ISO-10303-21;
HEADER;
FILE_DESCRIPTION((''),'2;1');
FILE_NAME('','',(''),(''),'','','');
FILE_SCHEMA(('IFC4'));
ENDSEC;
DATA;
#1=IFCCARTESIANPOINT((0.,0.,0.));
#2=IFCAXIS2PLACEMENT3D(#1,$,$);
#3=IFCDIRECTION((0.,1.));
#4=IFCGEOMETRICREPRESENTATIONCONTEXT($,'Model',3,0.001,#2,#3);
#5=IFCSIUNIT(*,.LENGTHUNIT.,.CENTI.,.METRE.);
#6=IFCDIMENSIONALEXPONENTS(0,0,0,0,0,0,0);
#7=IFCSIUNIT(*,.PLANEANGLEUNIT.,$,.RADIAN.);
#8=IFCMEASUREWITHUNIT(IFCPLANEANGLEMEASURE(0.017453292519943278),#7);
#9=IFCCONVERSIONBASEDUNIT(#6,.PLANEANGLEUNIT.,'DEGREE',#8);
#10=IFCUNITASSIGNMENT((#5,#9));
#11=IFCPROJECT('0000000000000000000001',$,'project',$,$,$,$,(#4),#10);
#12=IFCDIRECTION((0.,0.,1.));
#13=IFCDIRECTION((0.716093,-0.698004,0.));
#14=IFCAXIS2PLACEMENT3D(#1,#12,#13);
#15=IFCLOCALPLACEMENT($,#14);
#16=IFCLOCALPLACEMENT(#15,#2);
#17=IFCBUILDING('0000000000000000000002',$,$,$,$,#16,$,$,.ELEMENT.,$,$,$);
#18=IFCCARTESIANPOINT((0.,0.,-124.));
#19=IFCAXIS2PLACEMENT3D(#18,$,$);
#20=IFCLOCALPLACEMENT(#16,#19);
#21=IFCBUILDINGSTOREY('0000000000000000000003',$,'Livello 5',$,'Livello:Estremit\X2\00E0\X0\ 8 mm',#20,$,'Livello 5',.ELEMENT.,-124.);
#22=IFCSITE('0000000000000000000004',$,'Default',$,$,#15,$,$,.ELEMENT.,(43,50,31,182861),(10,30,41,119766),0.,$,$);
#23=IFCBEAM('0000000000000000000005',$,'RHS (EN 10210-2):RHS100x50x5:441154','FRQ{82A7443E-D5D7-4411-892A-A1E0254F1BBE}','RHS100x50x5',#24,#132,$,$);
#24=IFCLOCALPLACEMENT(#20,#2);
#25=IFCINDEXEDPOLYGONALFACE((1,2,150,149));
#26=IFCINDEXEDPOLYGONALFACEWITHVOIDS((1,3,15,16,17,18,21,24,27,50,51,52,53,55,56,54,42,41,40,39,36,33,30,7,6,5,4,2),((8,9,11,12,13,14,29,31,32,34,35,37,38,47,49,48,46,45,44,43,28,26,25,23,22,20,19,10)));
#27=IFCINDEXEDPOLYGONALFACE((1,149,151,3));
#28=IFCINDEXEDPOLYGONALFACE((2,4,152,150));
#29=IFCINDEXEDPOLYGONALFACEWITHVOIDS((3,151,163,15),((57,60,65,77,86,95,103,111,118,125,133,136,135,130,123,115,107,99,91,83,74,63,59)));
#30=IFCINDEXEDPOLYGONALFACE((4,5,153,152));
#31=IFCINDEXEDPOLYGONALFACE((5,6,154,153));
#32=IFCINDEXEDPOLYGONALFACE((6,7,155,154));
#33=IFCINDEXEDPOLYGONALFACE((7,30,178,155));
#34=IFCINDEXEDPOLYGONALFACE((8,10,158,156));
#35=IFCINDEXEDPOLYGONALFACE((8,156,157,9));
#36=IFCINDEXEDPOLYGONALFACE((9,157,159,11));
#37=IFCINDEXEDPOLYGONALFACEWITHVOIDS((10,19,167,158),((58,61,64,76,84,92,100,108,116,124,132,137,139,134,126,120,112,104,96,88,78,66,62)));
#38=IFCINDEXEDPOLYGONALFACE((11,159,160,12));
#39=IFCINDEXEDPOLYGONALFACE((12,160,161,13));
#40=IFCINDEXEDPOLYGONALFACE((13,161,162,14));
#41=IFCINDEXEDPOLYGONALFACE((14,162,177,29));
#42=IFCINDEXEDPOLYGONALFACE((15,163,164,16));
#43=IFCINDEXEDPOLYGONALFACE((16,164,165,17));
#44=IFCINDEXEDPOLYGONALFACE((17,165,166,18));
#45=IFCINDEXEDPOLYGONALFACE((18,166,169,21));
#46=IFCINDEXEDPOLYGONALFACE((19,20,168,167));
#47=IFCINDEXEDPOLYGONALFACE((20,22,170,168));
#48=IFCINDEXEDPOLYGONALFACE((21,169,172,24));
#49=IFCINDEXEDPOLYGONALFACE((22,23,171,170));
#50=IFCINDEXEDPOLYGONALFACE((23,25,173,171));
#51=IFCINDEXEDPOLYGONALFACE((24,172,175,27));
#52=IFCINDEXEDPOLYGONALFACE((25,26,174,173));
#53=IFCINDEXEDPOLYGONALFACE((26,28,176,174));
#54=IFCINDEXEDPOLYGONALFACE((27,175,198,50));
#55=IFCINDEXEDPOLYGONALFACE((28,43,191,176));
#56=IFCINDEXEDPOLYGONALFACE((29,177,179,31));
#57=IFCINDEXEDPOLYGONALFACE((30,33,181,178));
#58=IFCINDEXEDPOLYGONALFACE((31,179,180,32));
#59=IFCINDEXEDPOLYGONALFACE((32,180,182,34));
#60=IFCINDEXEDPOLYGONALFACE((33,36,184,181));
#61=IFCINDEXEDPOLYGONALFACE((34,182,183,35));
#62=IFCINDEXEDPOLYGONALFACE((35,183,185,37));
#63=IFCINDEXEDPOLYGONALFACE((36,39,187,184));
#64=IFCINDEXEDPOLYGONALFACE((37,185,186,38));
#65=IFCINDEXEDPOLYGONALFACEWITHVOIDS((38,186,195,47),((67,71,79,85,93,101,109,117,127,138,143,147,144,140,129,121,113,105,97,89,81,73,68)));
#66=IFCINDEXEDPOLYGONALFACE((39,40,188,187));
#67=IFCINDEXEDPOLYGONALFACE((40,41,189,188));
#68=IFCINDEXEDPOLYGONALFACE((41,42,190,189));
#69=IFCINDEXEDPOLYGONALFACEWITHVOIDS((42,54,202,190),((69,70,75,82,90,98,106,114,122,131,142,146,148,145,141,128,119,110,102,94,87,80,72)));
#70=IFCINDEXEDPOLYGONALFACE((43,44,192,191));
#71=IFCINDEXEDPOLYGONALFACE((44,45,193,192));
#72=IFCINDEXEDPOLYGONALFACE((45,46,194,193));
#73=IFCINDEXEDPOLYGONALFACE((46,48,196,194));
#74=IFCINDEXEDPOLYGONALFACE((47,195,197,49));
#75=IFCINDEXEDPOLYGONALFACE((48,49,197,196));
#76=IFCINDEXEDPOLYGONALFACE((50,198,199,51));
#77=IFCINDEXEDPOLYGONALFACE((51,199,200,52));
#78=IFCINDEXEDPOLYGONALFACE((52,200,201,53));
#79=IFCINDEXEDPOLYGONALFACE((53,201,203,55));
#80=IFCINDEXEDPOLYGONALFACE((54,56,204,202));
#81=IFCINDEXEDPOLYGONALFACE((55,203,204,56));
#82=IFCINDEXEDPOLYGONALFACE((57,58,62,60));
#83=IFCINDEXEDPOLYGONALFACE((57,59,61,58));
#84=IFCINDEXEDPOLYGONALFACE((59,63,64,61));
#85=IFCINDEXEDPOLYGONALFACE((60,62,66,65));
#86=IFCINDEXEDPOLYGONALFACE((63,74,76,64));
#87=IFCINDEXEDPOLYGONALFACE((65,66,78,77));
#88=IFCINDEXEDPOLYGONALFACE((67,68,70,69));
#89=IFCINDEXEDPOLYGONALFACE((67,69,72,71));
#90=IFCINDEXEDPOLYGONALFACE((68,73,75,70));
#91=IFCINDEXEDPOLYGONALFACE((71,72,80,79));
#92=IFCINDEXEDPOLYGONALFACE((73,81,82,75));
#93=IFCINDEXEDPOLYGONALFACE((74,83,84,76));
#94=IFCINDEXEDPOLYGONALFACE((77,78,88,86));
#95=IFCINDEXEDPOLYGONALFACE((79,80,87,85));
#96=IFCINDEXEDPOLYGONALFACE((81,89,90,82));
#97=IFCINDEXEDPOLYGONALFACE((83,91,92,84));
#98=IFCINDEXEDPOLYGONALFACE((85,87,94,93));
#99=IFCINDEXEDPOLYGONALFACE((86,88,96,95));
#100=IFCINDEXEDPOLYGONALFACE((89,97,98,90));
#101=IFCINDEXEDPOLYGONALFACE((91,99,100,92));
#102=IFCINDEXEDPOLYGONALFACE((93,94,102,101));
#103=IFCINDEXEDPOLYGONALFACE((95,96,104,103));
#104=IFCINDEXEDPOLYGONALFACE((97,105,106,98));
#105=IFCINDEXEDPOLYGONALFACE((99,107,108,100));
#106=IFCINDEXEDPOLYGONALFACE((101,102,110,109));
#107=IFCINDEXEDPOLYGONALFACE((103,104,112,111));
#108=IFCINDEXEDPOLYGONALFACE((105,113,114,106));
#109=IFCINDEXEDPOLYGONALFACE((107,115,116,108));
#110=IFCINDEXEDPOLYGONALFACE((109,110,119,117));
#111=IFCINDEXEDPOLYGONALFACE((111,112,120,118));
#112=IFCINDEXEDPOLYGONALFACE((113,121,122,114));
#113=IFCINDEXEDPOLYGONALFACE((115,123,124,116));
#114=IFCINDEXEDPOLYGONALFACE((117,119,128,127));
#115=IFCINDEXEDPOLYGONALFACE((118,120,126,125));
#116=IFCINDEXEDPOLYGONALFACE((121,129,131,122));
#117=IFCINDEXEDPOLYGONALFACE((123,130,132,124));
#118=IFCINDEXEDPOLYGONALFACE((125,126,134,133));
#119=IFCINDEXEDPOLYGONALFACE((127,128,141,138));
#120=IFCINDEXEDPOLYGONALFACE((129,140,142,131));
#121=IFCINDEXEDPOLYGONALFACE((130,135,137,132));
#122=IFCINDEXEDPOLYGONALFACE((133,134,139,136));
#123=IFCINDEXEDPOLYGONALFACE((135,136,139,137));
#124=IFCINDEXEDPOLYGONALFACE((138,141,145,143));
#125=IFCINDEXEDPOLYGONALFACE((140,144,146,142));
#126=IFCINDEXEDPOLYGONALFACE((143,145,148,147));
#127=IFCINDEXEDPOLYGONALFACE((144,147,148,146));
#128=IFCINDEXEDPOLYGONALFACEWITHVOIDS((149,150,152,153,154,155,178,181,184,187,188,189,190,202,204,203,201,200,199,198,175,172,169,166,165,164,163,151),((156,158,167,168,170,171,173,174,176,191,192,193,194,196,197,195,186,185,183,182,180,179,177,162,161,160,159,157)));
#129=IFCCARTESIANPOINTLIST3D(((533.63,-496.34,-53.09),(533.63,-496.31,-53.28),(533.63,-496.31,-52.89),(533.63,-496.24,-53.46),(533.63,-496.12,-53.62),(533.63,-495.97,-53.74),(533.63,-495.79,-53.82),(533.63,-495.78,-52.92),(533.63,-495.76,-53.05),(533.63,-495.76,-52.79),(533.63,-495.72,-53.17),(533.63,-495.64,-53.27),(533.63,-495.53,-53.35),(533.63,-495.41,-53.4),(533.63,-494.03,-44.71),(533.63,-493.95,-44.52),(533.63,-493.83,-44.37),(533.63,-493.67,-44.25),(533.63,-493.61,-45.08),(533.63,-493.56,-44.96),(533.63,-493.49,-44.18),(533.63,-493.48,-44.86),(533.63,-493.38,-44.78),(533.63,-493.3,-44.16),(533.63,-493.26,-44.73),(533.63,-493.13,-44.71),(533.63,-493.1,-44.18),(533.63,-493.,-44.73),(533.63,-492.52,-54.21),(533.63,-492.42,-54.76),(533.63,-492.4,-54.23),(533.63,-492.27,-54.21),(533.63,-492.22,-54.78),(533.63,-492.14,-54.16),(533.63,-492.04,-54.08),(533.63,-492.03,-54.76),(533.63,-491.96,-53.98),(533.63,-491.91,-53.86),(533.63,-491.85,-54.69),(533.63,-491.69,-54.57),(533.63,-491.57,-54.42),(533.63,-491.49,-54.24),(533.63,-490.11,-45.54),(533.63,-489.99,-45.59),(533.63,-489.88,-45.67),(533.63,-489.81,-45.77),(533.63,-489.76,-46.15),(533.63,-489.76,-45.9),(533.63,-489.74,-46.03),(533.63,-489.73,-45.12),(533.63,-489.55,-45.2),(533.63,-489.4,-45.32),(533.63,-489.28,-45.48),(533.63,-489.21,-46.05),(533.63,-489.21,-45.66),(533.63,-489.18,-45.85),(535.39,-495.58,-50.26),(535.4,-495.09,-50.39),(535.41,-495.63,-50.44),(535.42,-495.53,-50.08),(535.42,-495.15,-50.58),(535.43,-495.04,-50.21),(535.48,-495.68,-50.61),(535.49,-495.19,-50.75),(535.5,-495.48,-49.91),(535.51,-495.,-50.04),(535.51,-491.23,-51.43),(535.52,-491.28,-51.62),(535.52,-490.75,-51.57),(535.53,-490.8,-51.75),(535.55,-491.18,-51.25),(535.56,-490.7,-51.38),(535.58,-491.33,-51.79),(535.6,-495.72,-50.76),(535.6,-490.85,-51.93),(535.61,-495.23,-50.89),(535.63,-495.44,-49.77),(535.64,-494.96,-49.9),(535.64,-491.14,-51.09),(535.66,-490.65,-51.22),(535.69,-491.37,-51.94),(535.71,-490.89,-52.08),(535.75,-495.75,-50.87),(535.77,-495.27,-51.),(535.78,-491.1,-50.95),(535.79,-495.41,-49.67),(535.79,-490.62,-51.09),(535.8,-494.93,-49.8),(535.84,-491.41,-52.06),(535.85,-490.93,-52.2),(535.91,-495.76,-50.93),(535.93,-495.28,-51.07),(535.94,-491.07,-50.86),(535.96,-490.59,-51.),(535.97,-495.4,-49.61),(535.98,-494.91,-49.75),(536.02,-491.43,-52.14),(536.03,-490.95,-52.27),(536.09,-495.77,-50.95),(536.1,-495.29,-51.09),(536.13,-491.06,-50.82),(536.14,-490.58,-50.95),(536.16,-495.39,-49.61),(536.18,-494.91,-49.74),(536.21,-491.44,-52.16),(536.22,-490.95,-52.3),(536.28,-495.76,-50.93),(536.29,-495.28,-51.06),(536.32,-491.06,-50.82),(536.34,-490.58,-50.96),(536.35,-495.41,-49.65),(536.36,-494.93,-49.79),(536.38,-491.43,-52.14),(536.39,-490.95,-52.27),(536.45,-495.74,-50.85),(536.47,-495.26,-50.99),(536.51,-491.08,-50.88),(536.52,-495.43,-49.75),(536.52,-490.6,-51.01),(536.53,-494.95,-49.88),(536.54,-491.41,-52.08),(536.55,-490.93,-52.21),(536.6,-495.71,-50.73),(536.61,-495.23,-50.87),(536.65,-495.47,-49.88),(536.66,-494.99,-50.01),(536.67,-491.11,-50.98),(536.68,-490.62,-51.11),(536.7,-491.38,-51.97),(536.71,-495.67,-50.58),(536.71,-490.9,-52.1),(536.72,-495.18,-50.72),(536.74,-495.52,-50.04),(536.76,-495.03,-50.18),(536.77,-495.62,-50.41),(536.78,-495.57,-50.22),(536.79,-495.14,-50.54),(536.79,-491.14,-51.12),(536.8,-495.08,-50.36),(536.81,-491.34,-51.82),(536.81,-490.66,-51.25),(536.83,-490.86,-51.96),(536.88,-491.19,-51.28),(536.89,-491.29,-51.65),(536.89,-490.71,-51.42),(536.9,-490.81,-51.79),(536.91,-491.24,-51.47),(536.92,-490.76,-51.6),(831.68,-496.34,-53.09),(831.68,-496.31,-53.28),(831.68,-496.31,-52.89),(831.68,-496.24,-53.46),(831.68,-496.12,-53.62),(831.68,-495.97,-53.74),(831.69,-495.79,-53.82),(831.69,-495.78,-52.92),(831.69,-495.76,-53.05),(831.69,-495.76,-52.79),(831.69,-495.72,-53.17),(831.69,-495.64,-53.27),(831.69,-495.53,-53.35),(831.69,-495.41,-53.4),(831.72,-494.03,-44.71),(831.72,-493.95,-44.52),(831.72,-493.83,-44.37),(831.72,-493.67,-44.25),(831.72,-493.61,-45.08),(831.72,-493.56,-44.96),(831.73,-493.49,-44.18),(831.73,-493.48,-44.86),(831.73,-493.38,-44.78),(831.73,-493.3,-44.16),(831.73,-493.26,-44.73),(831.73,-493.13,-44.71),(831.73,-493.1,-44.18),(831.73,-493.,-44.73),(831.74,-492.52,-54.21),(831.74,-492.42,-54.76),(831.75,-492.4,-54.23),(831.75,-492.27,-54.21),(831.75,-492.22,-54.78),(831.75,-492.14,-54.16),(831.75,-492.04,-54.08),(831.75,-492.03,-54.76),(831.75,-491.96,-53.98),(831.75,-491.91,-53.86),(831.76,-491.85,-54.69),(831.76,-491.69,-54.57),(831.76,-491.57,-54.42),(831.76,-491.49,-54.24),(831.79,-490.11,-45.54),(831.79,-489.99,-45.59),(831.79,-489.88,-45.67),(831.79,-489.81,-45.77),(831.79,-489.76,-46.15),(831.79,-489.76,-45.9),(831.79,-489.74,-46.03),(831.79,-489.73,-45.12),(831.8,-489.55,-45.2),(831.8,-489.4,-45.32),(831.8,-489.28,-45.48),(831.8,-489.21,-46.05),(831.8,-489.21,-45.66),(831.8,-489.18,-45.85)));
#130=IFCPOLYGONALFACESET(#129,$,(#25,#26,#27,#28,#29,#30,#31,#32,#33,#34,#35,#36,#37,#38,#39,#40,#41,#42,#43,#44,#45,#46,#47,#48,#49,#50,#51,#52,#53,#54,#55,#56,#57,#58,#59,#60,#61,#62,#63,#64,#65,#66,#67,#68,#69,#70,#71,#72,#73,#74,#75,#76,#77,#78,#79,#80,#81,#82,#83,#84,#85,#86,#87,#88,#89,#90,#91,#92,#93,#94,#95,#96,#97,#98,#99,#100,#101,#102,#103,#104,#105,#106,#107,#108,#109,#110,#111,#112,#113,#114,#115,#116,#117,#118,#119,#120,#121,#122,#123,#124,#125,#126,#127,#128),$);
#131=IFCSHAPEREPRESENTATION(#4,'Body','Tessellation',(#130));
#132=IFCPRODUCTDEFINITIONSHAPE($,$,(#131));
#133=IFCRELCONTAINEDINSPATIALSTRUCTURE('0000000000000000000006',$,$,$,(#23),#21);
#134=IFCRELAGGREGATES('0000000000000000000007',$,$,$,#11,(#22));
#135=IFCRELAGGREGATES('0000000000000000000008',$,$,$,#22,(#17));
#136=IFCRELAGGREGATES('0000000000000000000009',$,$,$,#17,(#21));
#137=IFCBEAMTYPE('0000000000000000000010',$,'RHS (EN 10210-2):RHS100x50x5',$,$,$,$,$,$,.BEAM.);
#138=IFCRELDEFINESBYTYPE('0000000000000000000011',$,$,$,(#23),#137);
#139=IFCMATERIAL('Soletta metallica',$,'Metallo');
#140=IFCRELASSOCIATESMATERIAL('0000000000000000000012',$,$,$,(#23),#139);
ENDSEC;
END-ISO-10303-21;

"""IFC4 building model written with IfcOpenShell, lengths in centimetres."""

from ifc_helpers import new_model, entity, si_unit, converted_unit, direction, frame, frame_2d, origin, origin_2d, place, context, project, spatial, hollow_rectangle, circle, extrude, clip, halfspace, material, type_object, element, save


model = new_model("IFC4")

# Units and contexts
model_context = context("Model", 3, precision=0.001, world=origin(), true_north=direction((0.0, 1.0)))
ifc_project = project(units=[si_unit("LENGTHUNIT", "METRE", prefix="CENTI"), converted_unit("PLANEANGLEUNIT", "DEGREE", entity("IfcPlaneAngleMeasure", 0.017453292519943278), si_unit("PLANEANGLEUNIT", "RADIAN"), dimensions=[0, 0, 0, 0, 0, 0, 0])], contexts=[model_context])

# Site, building, storey
site_placement = place(None, frame((0.0, 0.0, 0.0), z_axis=(0.0, 0.0, 1.0), x_axis=(0.716093, -0.698004, 0.0)))
site = spatial("IfcSite", under=ifc_project, at=site_placement, Name="Default", CompositionType="ELEMENT", RefLatitude=(43, 50, 31, 182861), RefLongitude=(10, 30, 41, 119766), RefElevation=0.0)
building_placement = place(site_placement, origin())
building = spatial("IfcBuilding", under=site, at=building_placement, CompositionType="ELEMENT")
storey_placement = place(building_placement, frame((0.0, 0.0, -124.0)))
storey = spatial("IfcBuildingStorey", under=building, at=storey_placement, Name="Livello 5", ObjectType="Livello:Estremità 8 mm", LongName="Livello 5", CompositionType="ELEMENT", Elevation=-124.0)

# Beam, openings
ifc_material_1 = material(Name="Soletta metallica", Category="Metallo")
beam_type_1 = type_object("IfcBeamType", Name="RHS (EN 10210-2):RHS100x50x5", PredefinedType="BEAM")
beam_1_placement = place(storey_placement, frame((849.34, -492.76, -49.47), z_axis=(1.0, 0.0, 0.0), x_axis=(0.0, 0.963256, -0.268584)))
beam_1 = element("IfcBeam", 1, at=beam_1_placement, inside=storey, type_object=beam_type_1, material=ifc_material_1, Name="RHS (EN 10210-2):RHS100x50x5:441154", Description="FRQ{82A7443E-D5D7-4411-892A-A1E0254F1BBE}", ObjectType="RHS100x50x5", context=model_context, shape_type="Clipping", body=[
    clip(extrude(hollow_rectangle(XDim=5.0, YDim=10.0, WallThickness=0.5, InnerFilletRadius=0.5, OuterFilletRadius=0.75, at=origin_2d()), origin(), (0.0, 0.0, -1.0), 315.71), halfspace(frame((413.69, 295.44, -9.11), z_axis=(0.0171, 0.004768, -0.999842), x_axis=(-0.963105, -0.268541, -0.017752)), True)),
])
opening_1_placement = place(beam_1_placement, frame((2.05, -1.5, -317.43), z_axis=(-0.999637, 0.000101, -0.026952), x_axis=(-0.000101, -1.0, 0.0)))
element("IfcOpeningElement", 2, at=opening_1_placement, cuts=beam_1, ObjectType="Opening", context=model_context, shape_type="SweptSolid", body=[
    extrude(circle(Radius=0.7, at=frame_2d((-0.01, -0.7), x_axis=(1.0, 0.0))), origin(), (0.0, 0.0, -1.0), 0.63),
])
opening_2_placement = place(beam_1_placement, frame((1.92, -1.54, -312.43), z_axis=(-0.999637, 0.000101, -0.026952), x_axis=(-0.000101, -1.0, 0.0)))
element("IfcOpeningElement", 3, at=opening_2_placement, cuts=beam_1, ObjectType="Opening", context=model_context, shape_type="SweptSolid", body=[
    extrude(circle(Radius=0.7, at=frame_2d((-0.01, -0.7), x_axis=(1.0, 0.0))), origin(), (0.0, 0.0, -1.0), 0.63),
])
opening_3_placement = place(beam_1_placement, frame((-2.45, -1.5, -317.55), z_axis=(-0.999637, 0.000101, -0.026952), x_axis=(-0.000101, -1.0, 0.0)))
element("IfcOpeningElement", 4, at=opening_3_placement, cuts=beam_1, ObjectType="Opening", context=model_context, shape_type="SweptSolid", body=[
    extrude(circle(Radius=0.7, at=frame_2d((-0.01, -0.7), x_axis=(1.0, 0.0))), origin(), (0.0, 0.0, -1.0), 0.63),
])
opening_4_placement = place(beam_1_placement, frame((-2.58, -1.54, -312.55), z_axis=(-0.999637, 0.000101, -0.026952), x_axis=(-0.000101, -1.0, 0.0)))
element("IfcOpeningElement", 5, at=opening_4_placement, cuts=beam_1, ObjectType="Opening", context=model_context, shape_type="SweptSolid", body=[
    extrude(circle(Radius=0.7, at=frame_2d((-0.01, -0.7), x_axis=(1.0, 0.0))), origin(), (0.0, 0.0, -1.0), 0.63),
])

save(model, "model.ifc")
